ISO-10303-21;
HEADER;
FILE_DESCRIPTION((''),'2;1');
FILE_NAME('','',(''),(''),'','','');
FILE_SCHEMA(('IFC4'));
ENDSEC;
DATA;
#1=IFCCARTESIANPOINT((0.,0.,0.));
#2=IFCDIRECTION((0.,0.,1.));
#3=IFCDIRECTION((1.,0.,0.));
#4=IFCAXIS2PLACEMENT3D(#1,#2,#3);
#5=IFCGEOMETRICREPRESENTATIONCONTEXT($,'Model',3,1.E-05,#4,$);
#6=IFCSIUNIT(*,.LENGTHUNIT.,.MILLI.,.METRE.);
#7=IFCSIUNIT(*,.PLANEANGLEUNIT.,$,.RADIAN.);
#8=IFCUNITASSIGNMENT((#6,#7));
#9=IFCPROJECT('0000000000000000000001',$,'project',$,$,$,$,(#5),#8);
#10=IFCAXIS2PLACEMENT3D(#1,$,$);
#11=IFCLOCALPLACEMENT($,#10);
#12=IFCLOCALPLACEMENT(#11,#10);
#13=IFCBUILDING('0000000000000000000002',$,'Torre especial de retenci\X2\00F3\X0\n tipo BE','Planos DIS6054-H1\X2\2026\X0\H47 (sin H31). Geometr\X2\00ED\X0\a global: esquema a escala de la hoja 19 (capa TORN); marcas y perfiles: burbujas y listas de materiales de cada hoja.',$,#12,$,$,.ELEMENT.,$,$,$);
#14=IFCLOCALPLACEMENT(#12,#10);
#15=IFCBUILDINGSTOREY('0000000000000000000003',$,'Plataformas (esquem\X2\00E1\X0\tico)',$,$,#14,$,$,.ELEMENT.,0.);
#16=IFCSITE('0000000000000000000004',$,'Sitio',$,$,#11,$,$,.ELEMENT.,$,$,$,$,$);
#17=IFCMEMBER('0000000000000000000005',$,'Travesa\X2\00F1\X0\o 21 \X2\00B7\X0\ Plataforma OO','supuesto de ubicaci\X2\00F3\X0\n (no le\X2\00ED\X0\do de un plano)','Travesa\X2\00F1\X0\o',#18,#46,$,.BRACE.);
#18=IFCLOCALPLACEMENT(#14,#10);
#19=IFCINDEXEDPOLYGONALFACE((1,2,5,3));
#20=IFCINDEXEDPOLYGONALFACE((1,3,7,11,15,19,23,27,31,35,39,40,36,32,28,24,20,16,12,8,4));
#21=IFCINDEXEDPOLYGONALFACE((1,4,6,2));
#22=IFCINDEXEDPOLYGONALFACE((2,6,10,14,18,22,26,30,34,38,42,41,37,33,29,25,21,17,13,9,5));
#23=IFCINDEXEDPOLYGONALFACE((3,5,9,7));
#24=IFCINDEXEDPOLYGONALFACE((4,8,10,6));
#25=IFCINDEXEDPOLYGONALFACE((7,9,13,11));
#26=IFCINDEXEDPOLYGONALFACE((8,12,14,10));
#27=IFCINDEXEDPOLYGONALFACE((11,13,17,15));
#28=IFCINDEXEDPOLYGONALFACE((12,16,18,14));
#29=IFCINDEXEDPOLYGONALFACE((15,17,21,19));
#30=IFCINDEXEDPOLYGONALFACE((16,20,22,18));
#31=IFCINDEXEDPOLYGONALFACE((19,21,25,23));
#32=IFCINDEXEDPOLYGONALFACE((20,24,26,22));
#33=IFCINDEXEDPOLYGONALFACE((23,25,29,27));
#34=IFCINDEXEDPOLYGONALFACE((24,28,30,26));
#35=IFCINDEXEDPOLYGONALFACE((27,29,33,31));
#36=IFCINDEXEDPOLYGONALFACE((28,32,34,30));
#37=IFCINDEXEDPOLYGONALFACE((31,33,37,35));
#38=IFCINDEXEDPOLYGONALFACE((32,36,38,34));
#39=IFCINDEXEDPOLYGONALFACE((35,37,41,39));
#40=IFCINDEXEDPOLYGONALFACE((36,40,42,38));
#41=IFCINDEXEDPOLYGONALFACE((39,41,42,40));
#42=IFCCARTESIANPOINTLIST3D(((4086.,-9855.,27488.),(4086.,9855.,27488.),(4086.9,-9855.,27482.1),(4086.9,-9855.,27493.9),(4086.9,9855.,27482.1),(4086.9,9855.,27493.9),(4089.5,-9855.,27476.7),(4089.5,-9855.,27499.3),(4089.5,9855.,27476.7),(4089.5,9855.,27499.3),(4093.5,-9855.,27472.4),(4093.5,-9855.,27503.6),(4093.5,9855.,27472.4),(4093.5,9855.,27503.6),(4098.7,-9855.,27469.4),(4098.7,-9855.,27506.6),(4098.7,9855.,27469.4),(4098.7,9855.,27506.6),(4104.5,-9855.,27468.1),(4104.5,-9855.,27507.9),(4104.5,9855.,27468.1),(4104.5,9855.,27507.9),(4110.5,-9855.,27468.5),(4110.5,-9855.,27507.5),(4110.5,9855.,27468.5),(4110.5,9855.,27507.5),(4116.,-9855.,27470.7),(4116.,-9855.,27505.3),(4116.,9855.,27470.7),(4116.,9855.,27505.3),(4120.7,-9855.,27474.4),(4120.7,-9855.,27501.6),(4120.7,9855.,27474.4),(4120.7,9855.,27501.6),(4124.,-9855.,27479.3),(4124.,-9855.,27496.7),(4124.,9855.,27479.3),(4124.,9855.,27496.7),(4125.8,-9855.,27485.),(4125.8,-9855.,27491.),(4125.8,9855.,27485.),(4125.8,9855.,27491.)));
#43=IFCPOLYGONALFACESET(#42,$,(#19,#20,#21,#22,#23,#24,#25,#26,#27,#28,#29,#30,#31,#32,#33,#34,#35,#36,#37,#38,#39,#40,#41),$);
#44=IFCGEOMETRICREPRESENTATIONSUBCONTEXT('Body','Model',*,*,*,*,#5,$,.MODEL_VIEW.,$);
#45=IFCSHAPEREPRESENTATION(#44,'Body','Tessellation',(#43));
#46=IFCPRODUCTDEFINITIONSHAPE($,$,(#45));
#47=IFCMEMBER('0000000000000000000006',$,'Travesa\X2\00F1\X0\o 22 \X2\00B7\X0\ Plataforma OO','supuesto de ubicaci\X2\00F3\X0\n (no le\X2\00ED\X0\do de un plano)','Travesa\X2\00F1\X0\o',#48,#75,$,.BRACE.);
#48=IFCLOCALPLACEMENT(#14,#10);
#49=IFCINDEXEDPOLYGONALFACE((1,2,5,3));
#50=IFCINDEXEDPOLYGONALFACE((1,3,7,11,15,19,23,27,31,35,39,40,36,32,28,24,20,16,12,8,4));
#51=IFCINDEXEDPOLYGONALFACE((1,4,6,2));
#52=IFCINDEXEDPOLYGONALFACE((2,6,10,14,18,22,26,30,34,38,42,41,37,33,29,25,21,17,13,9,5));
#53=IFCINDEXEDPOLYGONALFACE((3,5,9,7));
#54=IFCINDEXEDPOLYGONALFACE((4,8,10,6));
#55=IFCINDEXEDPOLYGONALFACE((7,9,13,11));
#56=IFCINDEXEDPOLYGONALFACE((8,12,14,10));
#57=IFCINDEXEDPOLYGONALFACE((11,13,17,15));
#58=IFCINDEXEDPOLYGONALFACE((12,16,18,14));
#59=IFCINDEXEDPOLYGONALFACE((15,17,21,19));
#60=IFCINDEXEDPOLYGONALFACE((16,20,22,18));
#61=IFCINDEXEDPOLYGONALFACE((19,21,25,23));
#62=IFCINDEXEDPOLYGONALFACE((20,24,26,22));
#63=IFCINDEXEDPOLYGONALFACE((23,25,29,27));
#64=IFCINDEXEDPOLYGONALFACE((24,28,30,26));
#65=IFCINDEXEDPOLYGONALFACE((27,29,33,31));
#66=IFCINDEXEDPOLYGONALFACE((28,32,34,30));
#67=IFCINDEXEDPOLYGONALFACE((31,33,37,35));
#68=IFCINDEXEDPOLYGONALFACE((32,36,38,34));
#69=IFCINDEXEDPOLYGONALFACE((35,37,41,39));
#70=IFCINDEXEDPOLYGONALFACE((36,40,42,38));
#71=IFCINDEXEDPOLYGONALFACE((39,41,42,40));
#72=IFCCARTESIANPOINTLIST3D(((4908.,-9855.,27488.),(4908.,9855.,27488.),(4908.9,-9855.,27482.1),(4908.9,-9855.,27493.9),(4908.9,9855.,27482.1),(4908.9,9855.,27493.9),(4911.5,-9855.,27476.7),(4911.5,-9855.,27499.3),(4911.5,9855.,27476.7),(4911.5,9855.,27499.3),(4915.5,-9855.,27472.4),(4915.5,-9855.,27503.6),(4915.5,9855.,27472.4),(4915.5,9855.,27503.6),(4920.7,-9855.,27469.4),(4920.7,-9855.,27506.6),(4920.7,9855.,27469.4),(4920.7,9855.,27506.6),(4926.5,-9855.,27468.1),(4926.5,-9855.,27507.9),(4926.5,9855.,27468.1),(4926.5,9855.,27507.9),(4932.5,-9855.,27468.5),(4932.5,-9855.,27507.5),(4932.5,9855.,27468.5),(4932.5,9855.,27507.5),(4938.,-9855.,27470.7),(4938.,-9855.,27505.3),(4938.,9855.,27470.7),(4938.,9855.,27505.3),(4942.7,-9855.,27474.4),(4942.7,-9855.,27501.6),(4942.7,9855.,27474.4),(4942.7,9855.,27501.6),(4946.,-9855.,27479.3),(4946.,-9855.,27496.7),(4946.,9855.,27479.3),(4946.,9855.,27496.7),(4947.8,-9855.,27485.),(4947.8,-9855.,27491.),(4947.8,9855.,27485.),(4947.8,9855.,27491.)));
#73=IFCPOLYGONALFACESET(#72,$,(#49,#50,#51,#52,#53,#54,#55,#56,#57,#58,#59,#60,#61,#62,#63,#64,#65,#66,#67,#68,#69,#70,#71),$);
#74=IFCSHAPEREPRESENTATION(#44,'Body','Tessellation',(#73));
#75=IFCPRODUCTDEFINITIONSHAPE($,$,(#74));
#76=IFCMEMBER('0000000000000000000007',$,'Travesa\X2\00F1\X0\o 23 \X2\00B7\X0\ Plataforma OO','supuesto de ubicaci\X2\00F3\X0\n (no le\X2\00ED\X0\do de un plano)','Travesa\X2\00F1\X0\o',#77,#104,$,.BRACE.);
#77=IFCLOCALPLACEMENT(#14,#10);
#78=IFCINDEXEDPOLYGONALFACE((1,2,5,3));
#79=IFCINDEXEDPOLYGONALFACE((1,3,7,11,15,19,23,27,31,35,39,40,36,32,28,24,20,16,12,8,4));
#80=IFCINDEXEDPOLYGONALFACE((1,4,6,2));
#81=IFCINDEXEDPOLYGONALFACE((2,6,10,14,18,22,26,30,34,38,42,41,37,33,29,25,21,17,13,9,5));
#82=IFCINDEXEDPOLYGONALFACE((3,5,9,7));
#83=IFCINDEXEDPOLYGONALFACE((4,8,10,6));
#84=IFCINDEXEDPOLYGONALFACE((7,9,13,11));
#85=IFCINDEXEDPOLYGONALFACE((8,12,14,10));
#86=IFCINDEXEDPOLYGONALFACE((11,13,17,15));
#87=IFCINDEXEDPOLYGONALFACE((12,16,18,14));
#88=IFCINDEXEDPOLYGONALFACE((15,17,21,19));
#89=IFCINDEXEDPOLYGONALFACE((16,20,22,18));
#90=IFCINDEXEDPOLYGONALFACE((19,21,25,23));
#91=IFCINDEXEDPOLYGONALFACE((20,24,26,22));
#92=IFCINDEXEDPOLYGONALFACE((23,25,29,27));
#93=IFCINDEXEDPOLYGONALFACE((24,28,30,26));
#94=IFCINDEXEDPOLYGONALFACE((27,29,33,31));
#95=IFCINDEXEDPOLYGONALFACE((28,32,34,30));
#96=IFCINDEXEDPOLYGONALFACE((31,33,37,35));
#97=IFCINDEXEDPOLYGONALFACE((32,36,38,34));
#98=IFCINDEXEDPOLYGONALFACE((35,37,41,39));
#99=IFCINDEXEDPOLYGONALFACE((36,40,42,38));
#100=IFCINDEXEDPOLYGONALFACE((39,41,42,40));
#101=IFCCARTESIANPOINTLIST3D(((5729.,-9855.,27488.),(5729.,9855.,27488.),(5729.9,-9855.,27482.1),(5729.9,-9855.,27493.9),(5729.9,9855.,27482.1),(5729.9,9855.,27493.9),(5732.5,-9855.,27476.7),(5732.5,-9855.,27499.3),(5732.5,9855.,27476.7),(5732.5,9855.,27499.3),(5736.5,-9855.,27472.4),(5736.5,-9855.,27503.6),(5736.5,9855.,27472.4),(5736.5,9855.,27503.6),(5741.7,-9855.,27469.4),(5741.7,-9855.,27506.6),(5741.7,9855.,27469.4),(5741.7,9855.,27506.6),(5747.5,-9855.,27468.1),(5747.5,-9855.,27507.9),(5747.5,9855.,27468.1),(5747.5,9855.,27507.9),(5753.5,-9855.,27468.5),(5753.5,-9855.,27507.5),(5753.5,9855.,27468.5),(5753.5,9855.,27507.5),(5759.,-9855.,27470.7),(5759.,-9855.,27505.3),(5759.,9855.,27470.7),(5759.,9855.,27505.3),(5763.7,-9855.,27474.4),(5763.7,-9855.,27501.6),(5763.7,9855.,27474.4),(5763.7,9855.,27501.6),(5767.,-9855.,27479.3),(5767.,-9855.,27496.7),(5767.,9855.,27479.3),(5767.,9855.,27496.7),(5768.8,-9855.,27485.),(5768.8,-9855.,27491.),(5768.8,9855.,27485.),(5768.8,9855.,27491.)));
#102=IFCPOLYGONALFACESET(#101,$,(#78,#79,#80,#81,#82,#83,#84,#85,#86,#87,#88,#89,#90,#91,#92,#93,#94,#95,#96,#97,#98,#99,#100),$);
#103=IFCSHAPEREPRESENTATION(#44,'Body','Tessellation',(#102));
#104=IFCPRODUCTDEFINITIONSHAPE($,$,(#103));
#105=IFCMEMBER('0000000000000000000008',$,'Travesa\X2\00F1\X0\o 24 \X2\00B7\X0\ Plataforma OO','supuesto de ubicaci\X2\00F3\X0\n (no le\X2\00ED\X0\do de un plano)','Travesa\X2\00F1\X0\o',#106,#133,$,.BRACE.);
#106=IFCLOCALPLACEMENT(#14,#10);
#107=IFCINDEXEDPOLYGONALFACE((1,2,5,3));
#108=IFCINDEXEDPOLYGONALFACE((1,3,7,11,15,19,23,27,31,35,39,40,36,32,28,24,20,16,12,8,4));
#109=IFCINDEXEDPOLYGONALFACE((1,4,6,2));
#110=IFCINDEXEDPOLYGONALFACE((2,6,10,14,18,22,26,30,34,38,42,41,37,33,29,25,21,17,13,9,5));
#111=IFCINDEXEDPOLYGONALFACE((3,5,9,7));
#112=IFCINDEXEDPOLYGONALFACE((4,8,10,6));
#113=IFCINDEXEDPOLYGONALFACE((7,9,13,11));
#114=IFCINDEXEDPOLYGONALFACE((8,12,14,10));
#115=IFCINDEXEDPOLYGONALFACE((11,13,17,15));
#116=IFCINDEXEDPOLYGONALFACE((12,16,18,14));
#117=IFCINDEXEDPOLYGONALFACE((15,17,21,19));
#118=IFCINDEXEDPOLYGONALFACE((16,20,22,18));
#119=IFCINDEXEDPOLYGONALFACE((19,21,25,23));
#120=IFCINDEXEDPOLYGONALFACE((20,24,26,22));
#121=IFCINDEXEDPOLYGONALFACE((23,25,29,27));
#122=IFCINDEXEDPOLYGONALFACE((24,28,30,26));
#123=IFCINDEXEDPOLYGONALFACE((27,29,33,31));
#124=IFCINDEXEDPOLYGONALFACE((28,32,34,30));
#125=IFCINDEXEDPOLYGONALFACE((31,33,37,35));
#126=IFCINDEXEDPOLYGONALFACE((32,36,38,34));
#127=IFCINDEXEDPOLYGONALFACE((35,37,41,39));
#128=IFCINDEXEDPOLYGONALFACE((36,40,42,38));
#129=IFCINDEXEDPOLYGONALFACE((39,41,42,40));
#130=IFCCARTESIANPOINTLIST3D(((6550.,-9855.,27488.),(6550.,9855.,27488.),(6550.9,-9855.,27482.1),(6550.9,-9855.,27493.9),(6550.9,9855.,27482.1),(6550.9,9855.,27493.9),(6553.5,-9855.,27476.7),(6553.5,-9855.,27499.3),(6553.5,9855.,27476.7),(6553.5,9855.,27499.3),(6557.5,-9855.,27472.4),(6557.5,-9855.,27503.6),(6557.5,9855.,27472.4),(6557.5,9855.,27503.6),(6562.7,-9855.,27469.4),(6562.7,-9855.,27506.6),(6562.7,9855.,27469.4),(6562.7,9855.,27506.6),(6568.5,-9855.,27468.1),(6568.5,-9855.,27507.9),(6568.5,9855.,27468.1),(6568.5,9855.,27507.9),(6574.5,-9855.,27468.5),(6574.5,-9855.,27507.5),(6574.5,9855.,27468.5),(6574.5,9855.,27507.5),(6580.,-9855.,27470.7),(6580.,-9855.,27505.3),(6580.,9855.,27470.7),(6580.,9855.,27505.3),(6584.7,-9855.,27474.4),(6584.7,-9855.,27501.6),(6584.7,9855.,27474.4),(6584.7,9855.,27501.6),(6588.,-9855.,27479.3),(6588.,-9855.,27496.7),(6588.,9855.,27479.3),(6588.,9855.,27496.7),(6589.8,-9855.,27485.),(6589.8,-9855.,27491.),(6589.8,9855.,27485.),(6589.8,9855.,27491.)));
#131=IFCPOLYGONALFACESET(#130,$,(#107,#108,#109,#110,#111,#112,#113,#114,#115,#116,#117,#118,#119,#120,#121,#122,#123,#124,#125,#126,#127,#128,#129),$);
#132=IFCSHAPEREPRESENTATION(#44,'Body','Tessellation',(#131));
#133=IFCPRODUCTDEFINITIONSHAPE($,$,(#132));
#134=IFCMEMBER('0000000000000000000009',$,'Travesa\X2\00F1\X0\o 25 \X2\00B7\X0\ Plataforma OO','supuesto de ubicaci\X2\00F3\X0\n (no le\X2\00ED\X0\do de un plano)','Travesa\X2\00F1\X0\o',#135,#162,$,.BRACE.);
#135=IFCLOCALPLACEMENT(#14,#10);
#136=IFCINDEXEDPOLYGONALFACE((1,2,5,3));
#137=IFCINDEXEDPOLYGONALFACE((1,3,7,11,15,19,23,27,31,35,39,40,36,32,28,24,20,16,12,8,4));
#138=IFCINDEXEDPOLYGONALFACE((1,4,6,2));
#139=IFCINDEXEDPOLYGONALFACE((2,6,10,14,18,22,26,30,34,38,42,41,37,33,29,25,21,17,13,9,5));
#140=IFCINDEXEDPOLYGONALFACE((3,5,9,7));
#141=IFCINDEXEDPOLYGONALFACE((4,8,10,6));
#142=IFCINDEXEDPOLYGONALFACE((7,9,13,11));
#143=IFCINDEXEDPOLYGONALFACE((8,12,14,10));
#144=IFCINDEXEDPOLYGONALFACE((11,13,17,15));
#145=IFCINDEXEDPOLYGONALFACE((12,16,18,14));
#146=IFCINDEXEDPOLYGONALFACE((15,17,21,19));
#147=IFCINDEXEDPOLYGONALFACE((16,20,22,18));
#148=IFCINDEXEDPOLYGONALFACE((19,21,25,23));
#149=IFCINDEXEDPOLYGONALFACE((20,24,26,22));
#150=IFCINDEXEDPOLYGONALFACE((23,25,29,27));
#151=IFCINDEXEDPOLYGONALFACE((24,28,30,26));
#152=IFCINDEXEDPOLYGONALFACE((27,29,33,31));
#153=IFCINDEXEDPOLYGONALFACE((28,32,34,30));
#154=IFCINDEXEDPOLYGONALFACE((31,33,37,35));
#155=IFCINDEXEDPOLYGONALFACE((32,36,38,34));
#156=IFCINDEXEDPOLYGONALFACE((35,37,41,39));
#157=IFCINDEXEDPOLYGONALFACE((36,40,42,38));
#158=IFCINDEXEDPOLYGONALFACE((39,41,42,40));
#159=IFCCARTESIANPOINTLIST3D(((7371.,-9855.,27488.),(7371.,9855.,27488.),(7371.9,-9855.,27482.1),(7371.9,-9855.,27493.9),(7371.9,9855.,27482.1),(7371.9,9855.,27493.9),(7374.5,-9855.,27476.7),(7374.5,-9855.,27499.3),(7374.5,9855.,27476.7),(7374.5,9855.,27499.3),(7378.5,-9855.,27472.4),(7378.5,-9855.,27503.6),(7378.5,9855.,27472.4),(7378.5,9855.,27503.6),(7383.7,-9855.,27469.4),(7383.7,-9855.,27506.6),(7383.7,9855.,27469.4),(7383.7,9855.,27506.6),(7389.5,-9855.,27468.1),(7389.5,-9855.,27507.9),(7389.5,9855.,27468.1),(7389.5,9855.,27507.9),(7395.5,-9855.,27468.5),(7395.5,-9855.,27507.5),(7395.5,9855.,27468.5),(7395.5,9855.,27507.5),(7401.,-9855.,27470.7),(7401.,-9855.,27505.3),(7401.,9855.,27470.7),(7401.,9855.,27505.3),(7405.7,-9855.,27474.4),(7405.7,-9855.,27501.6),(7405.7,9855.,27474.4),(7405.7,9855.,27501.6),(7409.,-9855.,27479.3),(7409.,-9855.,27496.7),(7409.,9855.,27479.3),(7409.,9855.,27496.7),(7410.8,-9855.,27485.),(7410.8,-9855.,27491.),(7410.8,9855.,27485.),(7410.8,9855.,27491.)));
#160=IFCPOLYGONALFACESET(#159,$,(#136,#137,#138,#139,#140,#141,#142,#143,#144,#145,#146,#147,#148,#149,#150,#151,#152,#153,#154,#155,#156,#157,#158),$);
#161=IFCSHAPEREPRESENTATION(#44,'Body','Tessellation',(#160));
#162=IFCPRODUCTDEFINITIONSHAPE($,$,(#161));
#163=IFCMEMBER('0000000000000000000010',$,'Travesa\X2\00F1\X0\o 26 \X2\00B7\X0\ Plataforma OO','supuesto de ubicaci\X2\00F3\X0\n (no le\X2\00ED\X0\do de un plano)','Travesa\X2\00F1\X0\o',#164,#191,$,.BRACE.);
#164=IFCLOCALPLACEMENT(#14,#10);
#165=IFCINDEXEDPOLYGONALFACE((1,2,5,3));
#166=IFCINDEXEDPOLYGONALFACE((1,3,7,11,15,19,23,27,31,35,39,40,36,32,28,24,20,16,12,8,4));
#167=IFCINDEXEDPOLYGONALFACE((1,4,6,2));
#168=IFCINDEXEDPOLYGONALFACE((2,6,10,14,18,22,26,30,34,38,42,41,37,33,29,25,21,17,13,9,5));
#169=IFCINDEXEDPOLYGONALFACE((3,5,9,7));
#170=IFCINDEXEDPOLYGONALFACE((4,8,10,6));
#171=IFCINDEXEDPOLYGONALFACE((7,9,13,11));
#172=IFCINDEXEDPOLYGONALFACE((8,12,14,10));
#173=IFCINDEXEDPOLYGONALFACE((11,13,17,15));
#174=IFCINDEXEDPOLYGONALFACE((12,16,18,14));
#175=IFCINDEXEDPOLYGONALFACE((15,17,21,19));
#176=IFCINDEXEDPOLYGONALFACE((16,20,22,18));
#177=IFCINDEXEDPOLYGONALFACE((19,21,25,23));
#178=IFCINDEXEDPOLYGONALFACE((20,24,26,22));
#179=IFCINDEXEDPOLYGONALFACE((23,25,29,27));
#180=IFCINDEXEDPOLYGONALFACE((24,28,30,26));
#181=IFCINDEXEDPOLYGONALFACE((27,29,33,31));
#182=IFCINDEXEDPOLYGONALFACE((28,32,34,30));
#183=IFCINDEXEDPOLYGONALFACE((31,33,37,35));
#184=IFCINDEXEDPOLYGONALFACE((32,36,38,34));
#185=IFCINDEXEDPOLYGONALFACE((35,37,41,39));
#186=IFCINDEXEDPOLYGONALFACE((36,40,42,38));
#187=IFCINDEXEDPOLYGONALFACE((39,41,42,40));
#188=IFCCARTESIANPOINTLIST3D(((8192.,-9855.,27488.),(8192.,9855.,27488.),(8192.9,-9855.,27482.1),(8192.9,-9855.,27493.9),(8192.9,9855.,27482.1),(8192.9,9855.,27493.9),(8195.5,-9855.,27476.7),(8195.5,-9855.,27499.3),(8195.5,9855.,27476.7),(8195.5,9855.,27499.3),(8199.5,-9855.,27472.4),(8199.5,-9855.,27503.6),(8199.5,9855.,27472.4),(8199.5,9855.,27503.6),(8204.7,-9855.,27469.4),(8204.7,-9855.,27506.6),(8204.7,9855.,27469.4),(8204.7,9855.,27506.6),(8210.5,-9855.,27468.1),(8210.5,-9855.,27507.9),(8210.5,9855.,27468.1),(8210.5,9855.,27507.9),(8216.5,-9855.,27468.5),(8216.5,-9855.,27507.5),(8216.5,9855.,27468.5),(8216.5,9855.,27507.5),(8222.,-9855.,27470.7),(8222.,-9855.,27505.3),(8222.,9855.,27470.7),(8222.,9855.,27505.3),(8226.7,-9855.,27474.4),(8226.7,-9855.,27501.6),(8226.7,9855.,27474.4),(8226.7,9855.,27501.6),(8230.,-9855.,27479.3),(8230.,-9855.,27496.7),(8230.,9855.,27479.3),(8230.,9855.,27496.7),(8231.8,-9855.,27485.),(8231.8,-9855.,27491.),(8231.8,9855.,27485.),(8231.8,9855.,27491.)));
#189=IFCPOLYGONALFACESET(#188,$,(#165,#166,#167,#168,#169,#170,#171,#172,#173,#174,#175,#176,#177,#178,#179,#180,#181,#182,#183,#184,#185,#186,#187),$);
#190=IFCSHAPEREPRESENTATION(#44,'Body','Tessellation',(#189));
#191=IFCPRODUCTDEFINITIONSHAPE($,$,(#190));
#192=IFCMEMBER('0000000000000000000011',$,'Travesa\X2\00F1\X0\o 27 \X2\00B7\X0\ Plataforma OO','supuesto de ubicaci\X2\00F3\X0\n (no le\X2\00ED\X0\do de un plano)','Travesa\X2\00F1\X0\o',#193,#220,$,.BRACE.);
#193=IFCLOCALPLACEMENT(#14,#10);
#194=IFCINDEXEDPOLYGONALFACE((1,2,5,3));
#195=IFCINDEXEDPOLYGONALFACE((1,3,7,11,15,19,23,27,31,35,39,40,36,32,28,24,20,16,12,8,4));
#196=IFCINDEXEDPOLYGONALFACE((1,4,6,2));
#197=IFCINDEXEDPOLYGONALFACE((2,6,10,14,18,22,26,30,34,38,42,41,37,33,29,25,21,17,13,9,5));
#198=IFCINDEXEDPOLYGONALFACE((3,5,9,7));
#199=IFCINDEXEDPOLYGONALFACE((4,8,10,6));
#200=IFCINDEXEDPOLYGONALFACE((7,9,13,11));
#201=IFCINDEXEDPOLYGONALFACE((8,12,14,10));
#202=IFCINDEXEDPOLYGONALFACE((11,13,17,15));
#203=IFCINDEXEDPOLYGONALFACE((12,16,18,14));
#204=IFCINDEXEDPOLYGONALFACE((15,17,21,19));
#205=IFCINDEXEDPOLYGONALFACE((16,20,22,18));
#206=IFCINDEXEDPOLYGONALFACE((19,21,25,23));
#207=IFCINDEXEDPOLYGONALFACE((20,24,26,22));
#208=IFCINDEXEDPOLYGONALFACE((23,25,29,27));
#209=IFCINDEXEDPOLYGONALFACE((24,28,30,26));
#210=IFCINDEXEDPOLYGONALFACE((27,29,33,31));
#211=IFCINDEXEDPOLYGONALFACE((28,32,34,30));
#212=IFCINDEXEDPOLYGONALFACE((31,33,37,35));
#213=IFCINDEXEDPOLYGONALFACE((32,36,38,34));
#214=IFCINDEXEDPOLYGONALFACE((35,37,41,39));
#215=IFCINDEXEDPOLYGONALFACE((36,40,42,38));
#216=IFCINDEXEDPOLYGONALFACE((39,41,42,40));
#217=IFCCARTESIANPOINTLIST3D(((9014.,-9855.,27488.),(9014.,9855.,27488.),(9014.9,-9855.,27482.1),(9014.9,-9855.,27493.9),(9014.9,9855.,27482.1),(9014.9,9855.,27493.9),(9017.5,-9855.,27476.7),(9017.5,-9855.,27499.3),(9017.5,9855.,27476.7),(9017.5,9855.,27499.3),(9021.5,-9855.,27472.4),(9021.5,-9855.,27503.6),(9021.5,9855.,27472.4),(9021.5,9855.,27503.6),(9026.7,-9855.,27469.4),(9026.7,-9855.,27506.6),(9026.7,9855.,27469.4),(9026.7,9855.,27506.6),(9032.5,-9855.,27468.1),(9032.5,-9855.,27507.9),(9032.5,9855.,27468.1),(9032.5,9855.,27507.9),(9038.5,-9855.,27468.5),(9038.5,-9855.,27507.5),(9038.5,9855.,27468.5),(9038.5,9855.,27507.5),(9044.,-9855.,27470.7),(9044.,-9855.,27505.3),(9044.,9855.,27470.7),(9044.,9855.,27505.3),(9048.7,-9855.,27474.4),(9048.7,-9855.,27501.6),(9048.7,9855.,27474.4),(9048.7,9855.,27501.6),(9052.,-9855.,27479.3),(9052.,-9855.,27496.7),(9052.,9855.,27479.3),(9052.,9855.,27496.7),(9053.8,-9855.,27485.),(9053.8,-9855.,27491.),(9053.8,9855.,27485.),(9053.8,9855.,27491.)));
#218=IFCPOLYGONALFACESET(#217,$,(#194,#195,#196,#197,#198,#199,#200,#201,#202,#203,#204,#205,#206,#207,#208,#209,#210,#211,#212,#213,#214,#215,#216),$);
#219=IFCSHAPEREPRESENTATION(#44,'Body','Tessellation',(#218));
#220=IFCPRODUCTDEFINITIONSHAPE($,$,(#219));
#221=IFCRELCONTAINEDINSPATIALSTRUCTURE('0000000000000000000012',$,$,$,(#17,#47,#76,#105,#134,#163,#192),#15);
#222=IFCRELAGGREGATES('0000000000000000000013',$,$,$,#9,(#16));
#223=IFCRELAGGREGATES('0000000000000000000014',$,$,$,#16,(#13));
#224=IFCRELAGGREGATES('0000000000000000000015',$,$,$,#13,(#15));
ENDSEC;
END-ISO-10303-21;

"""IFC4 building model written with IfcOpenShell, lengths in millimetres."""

from ifc_helpers import new_model, si_unit, frame, origin, origin_with_axes, place, context, subcontext, project, spatial, circle, extrude, element, save


model = new_model("IFC4")

# Units and contexts
model_context = context("Model", 3, precision=1e-05, world=origin_with_axes())
body_context = subcontext(model_context, "Body", "Model", "MODEL_VIEW")
ifc_project = project(units=[si_unit("LENGTHUNIT", "METRE", prefix="MILLI"), si_unit("PLANEANGLEUNIT", "RADIAN")], contexts=[model_context])

# Site, building, storey
site_placement = place(None, origin())
site = spatial("IfcSite", under=ifc_project, at=site_placement, Name="Sitio", CompositionType="ELEMENT")
building_placement = place(site_placement, origin())
building = spatial("IfcBuilding", under=site, at=building_placement, Name="Torre especial de retención tipo BE", Description="Planos DIS6054-H1…H47 (sin H31). Geometría global: esquema a escala de la hoja 19 (capa TORN); marcas y perfiles: burbujas y listas de materiales de cada hoja.", CompositionType="ELEMENT")
storey_placement = place(building_placement, origin())
storey = spatial("IfcBuildingStorey", under=building, at=storey_placement, Name="Plataformas (esquemático)", CompositionType="ELEMENT", Elevation=0.0)

# Members
for number, where, z_axis, x_axis, name in (
    (1, (4106.0, 9855.0, 27488.0), (0.0, -1.0, 0.0), (-1.0, 0.0, 0.0), "Travesaño 21 · Plataforma OO"),
    (2, (4928.0, 9855.0, 27488.0), (0.0, -1.0, 0.0), (-1.0, 0.0, 0.0), "Travesaño 22 · Plataforma OO"),
    (3, (5749.0, 9855.0, 27488.0), (0.0, -1.0, 0.0), (-1.0, 0.0, 0.0), "Travesaño 23 · Plataforma OO"),
    (4, (6570.0, 9855.0, 27488.0), (0.0, -1.0, 0.0), (-1.0, 0.0, 0.0), "Travesaño 24 · Plataforma OO"),
    (5, (7391.0, 9855.0, 27488.0), (0.0, -1.0, 0.0), (-1.0, 0.0, 0.0), "Travesaño 25 · Plataforma OO"),
    (6, (8212.0, 9855.0, 27488.0), (0.0, -1.0, 0.0), (-1.0, 0.0, 0.0), "Travesaño 26 · Plataforma OO"),
    (7, (9034.0, 9855.0, 27488.0), (0.0, -1.0, 0.0), (-1.0, 0.0, 0.0), "Travesaño 27 · Plataforma OO"),
):
    element("IfcMember", number, at=place(storey_placement, frame(where, z_axis=z_axis, x_axis=x_axis)), inside=storey, Name=name, Description="supuesto de ubicación (no leído de un plano)", ObjectType="Travesaño", PredefinedType="BRACE", context=body_context, shape_type="SweptSolid", body=[
        extrude(circle(Radius=20.0), None, (0.0, 0.0, 1.0), 19710.0),
    ])

save(model, "model.ifc")
